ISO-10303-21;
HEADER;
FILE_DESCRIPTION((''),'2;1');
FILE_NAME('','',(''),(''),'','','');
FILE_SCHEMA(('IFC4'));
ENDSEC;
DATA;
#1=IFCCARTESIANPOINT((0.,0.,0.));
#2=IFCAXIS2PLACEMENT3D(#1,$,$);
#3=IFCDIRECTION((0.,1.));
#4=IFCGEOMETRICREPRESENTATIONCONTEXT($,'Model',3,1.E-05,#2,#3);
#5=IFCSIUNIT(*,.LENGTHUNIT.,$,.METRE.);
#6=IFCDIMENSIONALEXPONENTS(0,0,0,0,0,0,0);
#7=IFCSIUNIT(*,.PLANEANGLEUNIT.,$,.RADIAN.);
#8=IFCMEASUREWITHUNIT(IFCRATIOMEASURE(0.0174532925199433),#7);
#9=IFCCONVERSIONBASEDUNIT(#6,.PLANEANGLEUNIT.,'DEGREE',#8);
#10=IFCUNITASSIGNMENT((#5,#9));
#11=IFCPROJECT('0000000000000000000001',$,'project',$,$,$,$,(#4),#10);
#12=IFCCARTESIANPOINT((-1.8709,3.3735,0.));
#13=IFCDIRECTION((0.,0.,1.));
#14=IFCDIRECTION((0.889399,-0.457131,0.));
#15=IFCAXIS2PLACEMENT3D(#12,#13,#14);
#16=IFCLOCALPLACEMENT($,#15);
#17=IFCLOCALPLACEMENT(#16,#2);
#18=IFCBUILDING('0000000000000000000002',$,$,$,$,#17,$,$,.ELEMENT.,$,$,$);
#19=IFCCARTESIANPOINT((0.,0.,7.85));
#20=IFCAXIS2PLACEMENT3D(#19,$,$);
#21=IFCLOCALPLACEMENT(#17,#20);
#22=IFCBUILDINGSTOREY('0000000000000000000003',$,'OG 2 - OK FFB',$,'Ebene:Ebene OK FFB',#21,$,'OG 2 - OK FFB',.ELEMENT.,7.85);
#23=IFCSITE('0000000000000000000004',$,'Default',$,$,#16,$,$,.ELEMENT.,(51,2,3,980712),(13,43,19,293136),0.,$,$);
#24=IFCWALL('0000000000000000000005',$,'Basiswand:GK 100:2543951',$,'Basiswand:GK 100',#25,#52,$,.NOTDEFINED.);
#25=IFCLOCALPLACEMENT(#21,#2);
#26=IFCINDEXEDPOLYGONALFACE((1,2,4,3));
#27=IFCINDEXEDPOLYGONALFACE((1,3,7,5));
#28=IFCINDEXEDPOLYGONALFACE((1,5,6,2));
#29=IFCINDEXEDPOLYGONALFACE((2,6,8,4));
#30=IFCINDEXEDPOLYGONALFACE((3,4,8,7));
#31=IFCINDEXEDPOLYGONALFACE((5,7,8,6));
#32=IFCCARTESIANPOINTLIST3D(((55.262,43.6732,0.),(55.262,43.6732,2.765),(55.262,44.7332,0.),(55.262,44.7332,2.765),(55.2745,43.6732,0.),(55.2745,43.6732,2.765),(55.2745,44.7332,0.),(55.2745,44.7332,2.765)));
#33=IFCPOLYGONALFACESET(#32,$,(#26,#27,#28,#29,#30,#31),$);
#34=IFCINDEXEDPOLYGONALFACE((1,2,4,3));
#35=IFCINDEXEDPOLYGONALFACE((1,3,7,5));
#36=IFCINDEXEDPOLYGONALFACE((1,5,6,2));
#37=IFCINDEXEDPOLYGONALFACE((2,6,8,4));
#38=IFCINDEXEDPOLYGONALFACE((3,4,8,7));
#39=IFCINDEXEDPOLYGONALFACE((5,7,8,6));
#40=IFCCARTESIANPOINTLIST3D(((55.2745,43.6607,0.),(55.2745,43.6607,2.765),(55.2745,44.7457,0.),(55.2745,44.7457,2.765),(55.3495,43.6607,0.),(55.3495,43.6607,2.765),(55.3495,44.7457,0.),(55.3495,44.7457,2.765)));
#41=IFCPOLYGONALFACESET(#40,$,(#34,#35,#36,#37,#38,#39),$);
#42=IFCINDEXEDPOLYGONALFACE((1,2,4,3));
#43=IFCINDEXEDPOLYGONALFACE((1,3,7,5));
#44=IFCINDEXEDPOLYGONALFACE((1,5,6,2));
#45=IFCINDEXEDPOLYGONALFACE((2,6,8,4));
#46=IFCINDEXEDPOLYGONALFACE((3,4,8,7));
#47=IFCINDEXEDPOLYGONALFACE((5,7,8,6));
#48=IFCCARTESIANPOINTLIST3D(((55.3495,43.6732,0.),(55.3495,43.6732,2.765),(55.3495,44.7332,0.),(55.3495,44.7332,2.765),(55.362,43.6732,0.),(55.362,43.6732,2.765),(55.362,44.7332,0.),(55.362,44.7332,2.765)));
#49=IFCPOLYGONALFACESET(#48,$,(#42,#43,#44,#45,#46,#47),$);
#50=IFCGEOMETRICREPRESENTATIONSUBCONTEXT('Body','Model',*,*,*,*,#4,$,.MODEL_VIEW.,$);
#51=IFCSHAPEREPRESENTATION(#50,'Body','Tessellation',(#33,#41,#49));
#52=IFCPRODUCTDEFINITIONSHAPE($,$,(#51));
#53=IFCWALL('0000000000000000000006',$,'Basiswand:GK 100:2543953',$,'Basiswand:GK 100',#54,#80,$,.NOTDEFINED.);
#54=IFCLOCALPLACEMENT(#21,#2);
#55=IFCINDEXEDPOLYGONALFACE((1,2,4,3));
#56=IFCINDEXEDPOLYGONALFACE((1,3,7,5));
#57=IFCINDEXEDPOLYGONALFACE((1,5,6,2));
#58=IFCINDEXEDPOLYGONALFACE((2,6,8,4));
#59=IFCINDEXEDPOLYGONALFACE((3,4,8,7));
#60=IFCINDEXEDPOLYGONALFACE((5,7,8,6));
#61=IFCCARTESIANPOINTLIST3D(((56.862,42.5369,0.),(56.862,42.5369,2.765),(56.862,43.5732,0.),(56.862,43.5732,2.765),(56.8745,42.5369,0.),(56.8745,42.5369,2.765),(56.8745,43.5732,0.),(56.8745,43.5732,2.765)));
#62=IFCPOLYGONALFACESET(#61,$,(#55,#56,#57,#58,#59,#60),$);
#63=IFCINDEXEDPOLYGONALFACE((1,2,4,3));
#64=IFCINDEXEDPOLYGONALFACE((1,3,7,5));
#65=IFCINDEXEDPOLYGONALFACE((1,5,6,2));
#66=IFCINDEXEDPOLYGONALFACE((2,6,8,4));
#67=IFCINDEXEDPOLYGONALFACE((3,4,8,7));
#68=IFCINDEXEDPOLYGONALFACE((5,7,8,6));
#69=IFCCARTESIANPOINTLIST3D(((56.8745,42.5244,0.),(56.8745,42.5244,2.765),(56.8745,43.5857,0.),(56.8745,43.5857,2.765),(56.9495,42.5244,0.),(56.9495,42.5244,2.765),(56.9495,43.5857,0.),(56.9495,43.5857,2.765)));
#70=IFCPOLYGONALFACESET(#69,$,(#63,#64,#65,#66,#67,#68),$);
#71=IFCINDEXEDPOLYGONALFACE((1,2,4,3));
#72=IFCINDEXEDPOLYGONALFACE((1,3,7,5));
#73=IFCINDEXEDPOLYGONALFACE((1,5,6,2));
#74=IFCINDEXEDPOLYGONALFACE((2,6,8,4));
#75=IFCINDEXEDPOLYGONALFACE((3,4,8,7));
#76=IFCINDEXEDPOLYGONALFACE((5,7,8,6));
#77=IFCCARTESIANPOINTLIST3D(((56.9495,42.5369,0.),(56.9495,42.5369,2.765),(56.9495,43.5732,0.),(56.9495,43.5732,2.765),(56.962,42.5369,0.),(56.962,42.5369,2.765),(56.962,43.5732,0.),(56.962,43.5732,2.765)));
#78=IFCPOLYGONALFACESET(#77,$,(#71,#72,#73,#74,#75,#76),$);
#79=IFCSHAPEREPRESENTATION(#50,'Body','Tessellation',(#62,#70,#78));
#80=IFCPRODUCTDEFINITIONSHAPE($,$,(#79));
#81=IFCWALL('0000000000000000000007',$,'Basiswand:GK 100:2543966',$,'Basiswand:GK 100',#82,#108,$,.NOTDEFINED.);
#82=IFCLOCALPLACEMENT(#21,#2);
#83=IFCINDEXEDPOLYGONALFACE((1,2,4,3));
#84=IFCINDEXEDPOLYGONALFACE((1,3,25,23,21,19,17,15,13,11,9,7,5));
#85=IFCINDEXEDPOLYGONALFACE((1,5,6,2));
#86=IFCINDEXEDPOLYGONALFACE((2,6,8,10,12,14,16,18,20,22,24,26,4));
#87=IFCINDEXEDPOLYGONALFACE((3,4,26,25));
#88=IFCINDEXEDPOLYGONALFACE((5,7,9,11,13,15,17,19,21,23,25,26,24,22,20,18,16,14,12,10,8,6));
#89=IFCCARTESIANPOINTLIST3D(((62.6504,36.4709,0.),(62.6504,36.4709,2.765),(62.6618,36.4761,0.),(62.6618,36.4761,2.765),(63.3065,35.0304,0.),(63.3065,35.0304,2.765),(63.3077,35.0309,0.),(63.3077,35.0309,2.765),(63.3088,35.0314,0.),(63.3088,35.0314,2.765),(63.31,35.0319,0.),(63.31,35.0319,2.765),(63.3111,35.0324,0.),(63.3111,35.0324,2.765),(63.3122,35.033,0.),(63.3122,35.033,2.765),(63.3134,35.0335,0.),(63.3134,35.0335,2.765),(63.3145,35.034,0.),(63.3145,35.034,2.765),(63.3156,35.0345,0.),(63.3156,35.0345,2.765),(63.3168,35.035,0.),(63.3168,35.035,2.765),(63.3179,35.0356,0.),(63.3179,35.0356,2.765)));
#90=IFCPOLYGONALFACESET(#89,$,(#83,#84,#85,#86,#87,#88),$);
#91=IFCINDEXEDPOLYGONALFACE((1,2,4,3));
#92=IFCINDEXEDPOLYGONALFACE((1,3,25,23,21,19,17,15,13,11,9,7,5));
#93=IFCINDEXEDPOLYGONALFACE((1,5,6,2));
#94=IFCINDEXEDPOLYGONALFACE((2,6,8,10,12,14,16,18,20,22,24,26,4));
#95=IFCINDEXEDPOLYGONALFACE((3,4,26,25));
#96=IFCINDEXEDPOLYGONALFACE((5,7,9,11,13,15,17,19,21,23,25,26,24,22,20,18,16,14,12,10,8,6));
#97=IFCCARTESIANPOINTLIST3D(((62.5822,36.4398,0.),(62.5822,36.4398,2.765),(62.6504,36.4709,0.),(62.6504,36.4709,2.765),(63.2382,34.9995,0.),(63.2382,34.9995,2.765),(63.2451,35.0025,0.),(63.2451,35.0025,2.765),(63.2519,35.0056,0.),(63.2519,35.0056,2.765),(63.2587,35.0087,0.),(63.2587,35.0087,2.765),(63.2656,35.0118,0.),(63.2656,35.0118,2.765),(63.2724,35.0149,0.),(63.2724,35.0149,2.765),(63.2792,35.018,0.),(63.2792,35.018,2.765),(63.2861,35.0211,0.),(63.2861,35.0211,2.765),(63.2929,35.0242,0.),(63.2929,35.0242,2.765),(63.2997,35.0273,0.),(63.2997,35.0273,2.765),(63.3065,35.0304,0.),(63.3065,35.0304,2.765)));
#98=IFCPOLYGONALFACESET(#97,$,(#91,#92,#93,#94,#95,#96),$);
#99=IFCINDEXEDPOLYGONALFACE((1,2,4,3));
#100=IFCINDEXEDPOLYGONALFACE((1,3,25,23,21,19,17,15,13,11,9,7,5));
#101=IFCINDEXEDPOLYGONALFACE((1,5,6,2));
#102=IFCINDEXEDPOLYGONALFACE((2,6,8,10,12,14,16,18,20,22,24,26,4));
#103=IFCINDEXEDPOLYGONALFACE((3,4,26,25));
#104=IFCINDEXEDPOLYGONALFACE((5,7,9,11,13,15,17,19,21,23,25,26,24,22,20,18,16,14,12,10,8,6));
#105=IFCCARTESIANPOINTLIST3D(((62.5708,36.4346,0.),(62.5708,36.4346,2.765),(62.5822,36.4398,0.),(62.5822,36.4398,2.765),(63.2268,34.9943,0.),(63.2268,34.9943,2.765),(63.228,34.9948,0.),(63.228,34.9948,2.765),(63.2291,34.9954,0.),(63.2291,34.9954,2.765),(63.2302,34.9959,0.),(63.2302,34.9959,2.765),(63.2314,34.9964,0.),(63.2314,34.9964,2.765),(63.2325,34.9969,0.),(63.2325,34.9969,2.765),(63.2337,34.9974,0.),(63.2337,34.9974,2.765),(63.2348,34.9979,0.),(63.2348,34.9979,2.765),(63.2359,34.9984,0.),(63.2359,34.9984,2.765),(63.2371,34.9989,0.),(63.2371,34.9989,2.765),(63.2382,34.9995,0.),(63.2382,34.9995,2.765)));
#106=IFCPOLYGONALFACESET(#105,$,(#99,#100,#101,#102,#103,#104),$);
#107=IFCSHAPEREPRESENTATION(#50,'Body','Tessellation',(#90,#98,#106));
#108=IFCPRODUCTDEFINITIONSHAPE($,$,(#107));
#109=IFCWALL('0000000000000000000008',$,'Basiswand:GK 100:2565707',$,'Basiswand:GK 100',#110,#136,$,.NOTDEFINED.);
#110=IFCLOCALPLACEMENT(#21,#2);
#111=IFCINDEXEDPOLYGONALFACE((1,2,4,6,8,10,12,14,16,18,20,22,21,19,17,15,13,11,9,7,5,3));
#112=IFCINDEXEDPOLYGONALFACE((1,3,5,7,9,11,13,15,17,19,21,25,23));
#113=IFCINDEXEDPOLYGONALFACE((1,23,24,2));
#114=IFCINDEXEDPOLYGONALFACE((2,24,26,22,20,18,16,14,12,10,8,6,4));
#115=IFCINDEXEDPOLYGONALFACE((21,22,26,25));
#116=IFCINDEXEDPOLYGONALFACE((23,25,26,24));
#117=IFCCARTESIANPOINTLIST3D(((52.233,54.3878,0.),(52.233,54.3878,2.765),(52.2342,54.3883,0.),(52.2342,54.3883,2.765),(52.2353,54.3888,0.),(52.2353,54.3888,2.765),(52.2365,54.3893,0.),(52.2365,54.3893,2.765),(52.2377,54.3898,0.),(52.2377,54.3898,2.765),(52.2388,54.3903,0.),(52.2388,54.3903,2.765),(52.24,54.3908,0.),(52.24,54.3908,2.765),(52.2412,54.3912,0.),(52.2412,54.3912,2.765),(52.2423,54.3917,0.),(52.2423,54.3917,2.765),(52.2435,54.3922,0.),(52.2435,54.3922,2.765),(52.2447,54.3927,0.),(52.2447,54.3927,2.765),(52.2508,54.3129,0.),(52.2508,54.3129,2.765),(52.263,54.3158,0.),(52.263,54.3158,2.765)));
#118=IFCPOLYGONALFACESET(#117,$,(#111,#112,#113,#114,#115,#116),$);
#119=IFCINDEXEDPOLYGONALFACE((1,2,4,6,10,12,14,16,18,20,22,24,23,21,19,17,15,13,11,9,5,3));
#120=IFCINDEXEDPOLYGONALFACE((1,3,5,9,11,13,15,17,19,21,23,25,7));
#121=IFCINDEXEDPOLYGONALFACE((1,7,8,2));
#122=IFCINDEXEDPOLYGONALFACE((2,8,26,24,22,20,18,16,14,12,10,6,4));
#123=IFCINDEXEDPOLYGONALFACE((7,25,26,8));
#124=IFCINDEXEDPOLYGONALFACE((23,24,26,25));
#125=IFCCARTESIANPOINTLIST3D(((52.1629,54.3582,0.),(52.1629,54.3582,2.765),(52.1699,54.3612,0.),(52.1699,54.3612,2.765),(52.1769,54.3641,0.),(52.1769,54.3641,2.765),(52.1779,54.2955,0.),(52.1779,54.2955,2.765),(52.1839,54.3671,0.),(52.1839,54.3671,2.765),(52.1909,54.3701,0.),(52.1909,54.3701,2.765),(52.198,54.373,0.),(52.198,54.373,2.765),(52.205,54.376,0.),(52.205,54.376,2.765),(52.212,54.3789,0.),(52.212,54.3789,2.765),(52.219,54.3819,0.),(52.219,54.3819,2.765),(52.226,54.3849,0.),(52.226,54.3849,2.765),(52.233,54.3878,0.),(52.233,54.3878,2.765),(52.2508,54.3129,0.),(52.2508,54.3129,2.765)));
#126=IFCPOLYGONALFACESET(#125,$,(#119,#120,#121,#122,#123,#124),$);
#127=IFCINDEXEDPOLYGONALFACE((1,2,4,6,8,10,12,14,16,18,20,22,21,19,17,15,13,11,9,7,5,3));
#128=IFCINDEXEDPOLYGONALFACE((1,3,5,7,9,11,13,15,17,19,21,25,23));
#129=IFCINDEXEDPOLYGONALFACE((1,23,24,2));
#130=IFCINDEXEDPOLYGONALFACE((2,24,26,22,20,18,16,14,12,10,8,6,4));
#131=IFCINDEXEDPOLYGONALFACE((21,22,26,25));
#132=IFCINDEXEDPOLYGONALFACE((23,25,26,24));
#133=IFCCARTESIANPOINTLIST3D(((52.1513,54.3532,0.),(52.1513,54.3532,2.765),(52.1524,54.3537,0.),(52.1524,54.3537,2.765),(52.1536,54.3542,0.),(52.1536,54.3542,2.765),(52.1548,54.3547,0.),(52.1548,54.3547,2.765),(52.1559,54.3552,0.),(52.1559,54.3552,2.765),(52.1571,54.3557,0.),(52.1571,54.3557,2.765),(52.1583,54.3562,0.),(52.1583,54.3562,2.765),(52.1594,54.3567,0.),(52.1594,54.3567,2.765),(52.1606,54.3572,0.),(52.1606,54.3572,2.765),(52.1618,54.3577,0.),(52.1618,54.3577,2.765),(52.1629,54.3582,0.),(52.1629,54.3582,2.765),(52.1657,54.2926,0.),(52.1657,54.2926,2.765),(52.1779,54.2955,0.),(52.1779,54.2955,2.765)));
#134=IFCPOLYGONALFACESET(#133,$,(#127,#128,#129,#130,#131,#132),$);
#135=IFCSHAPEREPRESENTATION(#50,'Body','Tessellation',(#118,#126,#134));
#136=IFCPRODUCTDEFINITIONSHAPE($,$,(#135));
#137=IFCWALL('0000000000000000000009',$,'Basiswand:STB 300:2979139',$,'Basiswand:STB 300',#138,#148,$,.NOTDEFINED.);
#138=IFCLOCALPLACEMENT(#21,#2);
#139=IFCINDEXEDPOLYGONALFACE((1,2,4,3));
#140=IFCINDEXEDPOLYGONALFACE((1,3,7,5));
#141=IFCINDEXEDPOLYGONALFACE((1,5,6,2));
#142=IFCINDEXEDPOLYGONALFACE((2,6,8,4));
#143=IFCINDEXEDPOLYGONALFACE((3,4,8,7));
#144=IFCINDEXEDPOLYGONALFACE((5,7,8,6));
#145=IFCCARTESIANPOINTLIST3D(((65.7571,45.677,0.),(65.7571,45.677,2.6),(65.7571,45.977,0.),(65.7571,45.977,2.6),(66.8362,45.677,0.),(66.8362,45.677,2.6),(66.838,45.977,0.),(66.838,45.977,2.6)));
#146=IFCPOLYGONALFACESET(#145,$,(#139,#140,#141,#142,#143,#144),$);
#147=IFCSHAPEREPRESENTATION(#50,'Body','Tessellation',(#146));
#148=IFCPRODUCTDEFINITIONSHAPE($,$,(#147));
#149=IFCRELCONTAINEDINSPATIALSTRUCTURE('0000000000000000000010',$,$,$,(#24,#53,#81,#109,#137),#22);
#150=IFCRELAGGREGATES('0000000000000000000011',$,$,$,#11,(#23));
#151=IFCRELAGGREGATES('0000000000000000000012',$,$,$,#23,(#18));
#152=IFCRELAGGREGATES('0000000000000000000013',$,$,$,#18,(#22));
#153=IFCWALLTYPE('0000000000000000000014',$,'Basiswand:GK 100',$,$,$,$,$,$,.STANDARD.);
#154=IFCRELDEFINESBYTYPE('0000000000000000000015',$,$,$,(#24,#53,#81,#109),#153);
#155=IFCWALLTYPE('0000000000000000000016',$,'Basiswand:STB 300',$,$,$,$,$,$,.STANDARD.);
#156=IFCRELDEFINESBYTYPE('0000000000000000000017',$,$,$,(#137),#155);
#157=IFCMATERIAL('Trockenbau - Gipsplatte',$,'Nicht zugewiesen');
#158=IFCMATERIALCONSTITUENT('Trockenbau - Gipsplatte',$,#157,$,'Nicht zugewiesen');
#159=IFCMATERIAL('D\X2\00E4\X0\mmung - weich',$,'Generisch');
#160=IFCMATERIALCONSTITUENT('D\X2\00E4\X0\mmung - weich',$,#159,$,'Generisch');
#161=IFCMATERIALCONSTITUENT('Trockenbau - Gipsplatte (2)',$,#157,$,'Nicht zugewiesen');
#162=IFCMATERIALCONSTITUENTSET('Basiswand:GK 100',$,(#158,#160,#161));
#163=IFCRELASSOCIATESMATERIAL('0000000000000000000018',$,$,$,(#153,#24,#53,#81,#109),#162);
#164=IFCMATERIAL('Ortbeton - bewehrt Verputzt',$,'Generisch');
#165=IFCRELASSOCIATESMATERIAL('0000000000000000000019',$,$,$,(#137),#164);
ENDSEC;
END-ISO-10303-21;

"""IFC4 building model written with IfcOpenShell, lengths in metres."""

from ifc_helpers import new_model, entity, si_unit, converted_unit, direction, frame, origin, place, context, subcontext, project, spatial, indexed_curve, outline, extrude, material, constituent, constituent_set, type_object, element, save


model = new_model("IFC4")

# Units and contexts
model_context = context("Model", 3, precision=1e-05, world=origin(), true_north=direction((0.0, 1.0)))
body_context = subcontext(model_context, "Body", "Model", "MODEL_VIEW")
ifc_project = project(units=[si_unit("LENGTHUNIT", "METRE"), converted_unit("PLANEANGLEUNIT", "DEGREE", entity("IfcRatioMeasure", 0.0174532925199433), si_unit("PLANEANGLEUNIT", "RADIAN"), dimensions=[0, 0, 0, 0, 0, 0, 0])], contexts=[model_context])

# Site, building, storey
site_placement = place(None, frame((-1.8709, 3.3735, 0.0), z_axis=(0.0, 0.0, 1.0), x_axis=(0.889399, -0.457131, 0.0)))
site = spatial("IfcSite", under=ifc_project, at=site_placement, Name="Default", CompositionType="ELEMENT", RefLatitude=(51, 2, 3, 980712), RefLongitude=(13, 43, 19, 293136), RefElevation=0.0)
building_placement = place(site_placement, origin())
building = spatial("IfcBuilding", under=site, at=building_placement, CompositionType="ELEMENT")
storey_placement = place(building_placement, frame((0.0, 0.0, 7.85)))
storey = spatial("IfcBuildingStorey", under=building, at=storey_placement, Name="OG 2 - OK FFB", ObjectType="Ebene:Ebene OK FFB", LongName="OG 2 - OK FFB", CompositionType="ELEMENT", Elevation=7.85)

# Shared definitions
ifc_material_1 = material(Name="Trockenbau - Gipsplatte", Category="Nicht zugewiesen")
ifc_constituent_1 = constituent(ifc_material_1, Name="Trockenbau - Gipsplatte", Category="Nicht zugewiesen")
ifc_material_2 = material(Name="Dämmung - weich", Category="Generisch")
ifc_constituent_2 = constituent(ifc_material_2, Name="Dämmung - weich", Category="Generisch")
ifc_constituent_3 = constituent(ifc_material_1, Name="Trockenbau - Gipsplatte (2)", Category="Nicht zugewiesen")
ifc_constituent_set_1 = constituent_set(constituents=[ifc_constituent_1, ifc_constituent_2, ifc_constituent_3], Name="Basiswand:GK 100")
wall_type_1 = type_object("IfcWallType", Name="Basiswand:GK 100", PredefinedType="STANDARD", material=ifc_constituent_set_1)

# Walls
wall_1_placement = place(storey_placement, frame((55.312, 44.7332, 0.0), z_axis=(0.0, 0.0, 1.0), x_axis=(0.0, -1.0, 0.0)))
element("IfcWall", 1, at=wall_1_placement, inside=storey, type_object=wall_type_1, material=ifc_constituent_set_1, Name="Basiswand:GK 100:2543951", ObjectType="Basiswand:GK 100", PredefinedType="NOTDEFINED", context=body_context, shape_type="SweptSolid", body=[
    extrude(outline(indexed_curve([(-0.0063, -0.53), (0.0063, -0.53), (0.0063, 0.53), (-0.0063, 0.53), (-0.0063, -0.53)], self_intersect=False)), frame((0.53, -0.0438, 0.0), z_axis=(0.0, 0.0, 1.0), x_axis=(0.0, 1.0, 0.0)), (0.0, 0.0, 1.0), 2.765),
    extrude(outline(indexed_curve([(-0.5425, -0.0375), (0.5425, -0.0375), (0.5425, 0.0375), (-0.5425, 0.0375), (-0.5425, -0.0375)], self_intersect=False)), frame((0.53, 0.0, 0.0)), (0.0, 0.0, 1.0), 2.765),
    extrude(outline(indexed_curve([(-0.0063, -0.53), (0.0062, -0.53), (0.0062, 0.53), (-0.0063, 0.53), (-0.0063, -0.53)], self_intersect=False)), frame((0.53, 0.0437, 0.0), z_axis=(0.0, 0.0, 1.0), x_axis=(0.0, -1.0, 0.0)), (0.0, 0.0, 1.0), 2.765),
])
wall_2_placement = place(storey_placement, frame((56.912, 43.5732, 0.0), z_axis=(0.0, 0.0, 1.0), x_axis=(0.0, -1.0, 0.0)))
element("IfcWall", 2, at=wall_2_placement, inside=storey, type_object=wall_type_1, material=ifc_constituent_set_1, Name="Basiswand:GK 100:2543953", ObjectType="Basiswand:GK 100", PredefinedType="NOTDEFINED", context=body_context, shape_type="SweptSolid", body=[
    extrude(outline(indexed_curve([(-0.0063, -0.5182), (0.0063, -0.5182), (0.0063, 0.5182), (-0.0063, 0.5182), (-0.0063, -0.5182)], self_intersect=False)), frame((0.5182, -0.0438, 0.0), z_axis=(0.0, 0.0, 1.0), x_axis=(0.0, 1.0, 0.0)), (0.0, 0.0, 1.0), 2.765),
    extrude(outline(indexed_curve([(-0.5307, -0.0375), (0.5307, -0.0375), (0.5307, 0.0375), (-0.5307, 0.0375), (-0.5307, -0.0375)], self_intersect=False)), frame((0.5182, 0.0, 0.0)), (0.0, 0.0, 1.0), 2.765),
    extrude(outline(indexed_curve([(-0.0063, -0.5182), (0.0062, -0.5182), (0.0062, 0.5182), (-0.0063, 0.5182), (-0.0063, -0.5182)], self_intersect=False)), frame((0.5182, 0.0437, 0.0), z_axis=(0.0, 0.0, 1.0), x_axis=(0.0, -1.0, 0.0)), (0.0, 0.0, 1.0), 2.765),
])
wall_3_placement = place(storey_placement, frame((63.2724, 35.0148, 0.0), z_axis=(0.0, 0.0, 1.0), x_axis=(-0.414495, 0.910051, 0.0)))
element("IfcWall", 3, at=wall_3_placement, inside=storey, type_object=wall_type_1, material=ifc_constituent_set_1, Name="Basiswand:GK 100:2543966", ObjectType="Basiswand:GK 100", PredefinedType="NOTDEFINED", context=body_context, shape_type="SweptSolid", body=[
    extrude(outline(indexed_curve([(-0.0062, -0.7914), (0.0063, -0.7914), (0.0062, 0.7914), (0.005, 0.7914), (0.0038, 0.7914), (0.0025, 0.7914), (0.0012, 0.7914), (0.0, 0.7914), (-0.0013, 0.7914), (-0.0025, 0.7914), (-0.0038, 0.7914), (-0.005, 0.7914), (-0.0063, 0.7914), (-0.0062, -0.7914)], self_intersect=False)), frame((0.7914, -0.0437, 0.0), z_axis=(0.0, 0.0, 1.0), x_axis=(0.0, 1.0, 0.0)), (0.0, 0.0, 1.0), 2.765),
    extrude(outline(indexed_curve([(-0.7915, -0.0375), (0.7914, -0.0375), (0.7914, 0.0375), (-0.7913, 0.0375), (-0.7913, 0.03), (-0.7914, 0.0225), (-0.7914, 0.015), (-0.7914, 0.0075), (-0.7914, 0.0), (-0.7914, -0.0075), (-0.7915, -0.015), (-0.7915, -0.0225), (-0.7915, -0.03), (-0.7915, -0.0375)], self_intersect=False)), frame((0.7915, 0.0, 0.0)), (0.0, 0.0, 1.0), 2.765),
    extrude(outline(indexed_curve([(-0.0024, -0.7913), (-0.0011, -0.7913), (0.0001, -0.7913), (0.0014, -0.7913), (0.0026, -0.7913), (0.0039, -0.7913), (0.0051, -0.7913), (0.0064, -0.7913), (0.0076, -0.7913), (0.0089, -0.7913), (0.0101, -0.7913), (0.0024, 0.7914), (-0.0101, 0.7913), (-0.0024, -0.7913)], self_intersect=False)), frame((0.7915, 0.0438, 0.0), z_axis=(0.0, 0.0, 1.0), x_axis=(-0.004878, -0.999988, 0.0)), (0.0, 0.0, 1.0), 2.765),
])
wall_4_placement = place(storey_placement, frame((52.2144, 54.3042, 0.0), z_axis=(0.0, 0.0, 1.0), x_axis=(-0.231842, 0.972754, 0.0)))
element("IfcWall", 4, at=wall_4_placement, inside=storey, type_object=wall_type_1, material=ifc_constituent_set_1, Name="Basiswand:GK 100:2565707", ObjectType="Basiswand:GK 100", PredefinedType="NOTDEFINED", context=body_context, shape_type="SweptSolid", body=[
    extrude(outline(indexed_curve([(-0.0127, -0.0385), (-0.0114, -0.0385), (-0.0102, -0.0385), (-0.0089, -0.0385), (-0.0076, -0.0385), (-0.0064, -0.0385), (-0.0051, -0.0385), (-0.0038, -0.0385), (-0.0026, -0.0385), (-0.0013, -0.0385), (0.0, -0.0385), (0.0125, 0.0375), (0.0002, 0.0395), (-0.0127, -0.0385)], self_intersect=False)), frame((0.039, -0.0438, 0.0), z_axis=(0.0, 0.0, 1.0), x_axis=(-0.163093, 0.986611, 0.0)), (0.0, 0.0, 1.0), 2.765),
    extrude(outline(indexed_curve([(-0.0354, -0.0375), (0.0417, -0.0375), (0.0404, -0.03), (0.0392, -0.0225), (0.0379, -0.015), (0.0367, -0.0075), (0.0354, 0.0), (0.0341, 0.0075), (0.0329, 0.015), (0.0316, 0.0225), (0.0304, 0.03), (0.0291, 0.0375), (-0.0354, 0.0375), (-0.0354, -0.0375)], self_intersect=False)), frame((0.0354, 0.0, 0.0)), (0.0, 0.0, 1.0), 2.765),
    extrude(outline(indexed_curve([(-0.0063, -0.0317), (0.0062, -0.0317), (0.0062, 0.0328), (0.005, 0.0325), (0.0037, 0.0323), (0.0025, 0.0321), (0.0012, 0.0319), (0.0, 0.0317), (-0.0013, 0.0315), (-0.0025, 0.0313), (-0.0038, 0.0311), (-0.005, 0.0308), (-0.0063, 0.0306), (-0.0063, -0.0317)], self_intersect=False)), frame((0.0317, 0.0437, 0.0), z_axis=(0.0, 0.0, 1.0), x_axis=(0.0, -1.0, 0.0)), (0.0, 0.0, 1.0), 2.765),
])
ifc_material_3 = material(Name="Ortbeton - bewehrt Verputzt", Category="Generisch")
wall_type_2 = type_object("IfcWallType", Name="Basiswand:STB 300", PredefinedType="STANDARD")
wall_5_placement = place(storey_placement, frame((66.838, 45.827, 0.0), z_axis=(0.0, 0.0, 1.0), x_axis=(-1.0, 0.0, 0.0)))
element("IfcWall", 5, at=wall_5_placement, inside=storey, type_object=wall_type_2, material=ifc_material_3, Name="Basiswand:STB 300:2979139", ObjectType="Basiswand:STB 300", PredefinedType="NOTDEFINED", context=body_context, shape_type="SweptSolid", body=[
    extrude(outline(indexed_curve([(1.0809, -0.15), (1.0809, 0.15), (0.0018, 0.15), (0.0, -0.15), (1.0809, -0.15)], self_intersect=False)), origin(), (0.0, 0.0, 1.0), 2.6),
])

save(model, "model.ifc")
